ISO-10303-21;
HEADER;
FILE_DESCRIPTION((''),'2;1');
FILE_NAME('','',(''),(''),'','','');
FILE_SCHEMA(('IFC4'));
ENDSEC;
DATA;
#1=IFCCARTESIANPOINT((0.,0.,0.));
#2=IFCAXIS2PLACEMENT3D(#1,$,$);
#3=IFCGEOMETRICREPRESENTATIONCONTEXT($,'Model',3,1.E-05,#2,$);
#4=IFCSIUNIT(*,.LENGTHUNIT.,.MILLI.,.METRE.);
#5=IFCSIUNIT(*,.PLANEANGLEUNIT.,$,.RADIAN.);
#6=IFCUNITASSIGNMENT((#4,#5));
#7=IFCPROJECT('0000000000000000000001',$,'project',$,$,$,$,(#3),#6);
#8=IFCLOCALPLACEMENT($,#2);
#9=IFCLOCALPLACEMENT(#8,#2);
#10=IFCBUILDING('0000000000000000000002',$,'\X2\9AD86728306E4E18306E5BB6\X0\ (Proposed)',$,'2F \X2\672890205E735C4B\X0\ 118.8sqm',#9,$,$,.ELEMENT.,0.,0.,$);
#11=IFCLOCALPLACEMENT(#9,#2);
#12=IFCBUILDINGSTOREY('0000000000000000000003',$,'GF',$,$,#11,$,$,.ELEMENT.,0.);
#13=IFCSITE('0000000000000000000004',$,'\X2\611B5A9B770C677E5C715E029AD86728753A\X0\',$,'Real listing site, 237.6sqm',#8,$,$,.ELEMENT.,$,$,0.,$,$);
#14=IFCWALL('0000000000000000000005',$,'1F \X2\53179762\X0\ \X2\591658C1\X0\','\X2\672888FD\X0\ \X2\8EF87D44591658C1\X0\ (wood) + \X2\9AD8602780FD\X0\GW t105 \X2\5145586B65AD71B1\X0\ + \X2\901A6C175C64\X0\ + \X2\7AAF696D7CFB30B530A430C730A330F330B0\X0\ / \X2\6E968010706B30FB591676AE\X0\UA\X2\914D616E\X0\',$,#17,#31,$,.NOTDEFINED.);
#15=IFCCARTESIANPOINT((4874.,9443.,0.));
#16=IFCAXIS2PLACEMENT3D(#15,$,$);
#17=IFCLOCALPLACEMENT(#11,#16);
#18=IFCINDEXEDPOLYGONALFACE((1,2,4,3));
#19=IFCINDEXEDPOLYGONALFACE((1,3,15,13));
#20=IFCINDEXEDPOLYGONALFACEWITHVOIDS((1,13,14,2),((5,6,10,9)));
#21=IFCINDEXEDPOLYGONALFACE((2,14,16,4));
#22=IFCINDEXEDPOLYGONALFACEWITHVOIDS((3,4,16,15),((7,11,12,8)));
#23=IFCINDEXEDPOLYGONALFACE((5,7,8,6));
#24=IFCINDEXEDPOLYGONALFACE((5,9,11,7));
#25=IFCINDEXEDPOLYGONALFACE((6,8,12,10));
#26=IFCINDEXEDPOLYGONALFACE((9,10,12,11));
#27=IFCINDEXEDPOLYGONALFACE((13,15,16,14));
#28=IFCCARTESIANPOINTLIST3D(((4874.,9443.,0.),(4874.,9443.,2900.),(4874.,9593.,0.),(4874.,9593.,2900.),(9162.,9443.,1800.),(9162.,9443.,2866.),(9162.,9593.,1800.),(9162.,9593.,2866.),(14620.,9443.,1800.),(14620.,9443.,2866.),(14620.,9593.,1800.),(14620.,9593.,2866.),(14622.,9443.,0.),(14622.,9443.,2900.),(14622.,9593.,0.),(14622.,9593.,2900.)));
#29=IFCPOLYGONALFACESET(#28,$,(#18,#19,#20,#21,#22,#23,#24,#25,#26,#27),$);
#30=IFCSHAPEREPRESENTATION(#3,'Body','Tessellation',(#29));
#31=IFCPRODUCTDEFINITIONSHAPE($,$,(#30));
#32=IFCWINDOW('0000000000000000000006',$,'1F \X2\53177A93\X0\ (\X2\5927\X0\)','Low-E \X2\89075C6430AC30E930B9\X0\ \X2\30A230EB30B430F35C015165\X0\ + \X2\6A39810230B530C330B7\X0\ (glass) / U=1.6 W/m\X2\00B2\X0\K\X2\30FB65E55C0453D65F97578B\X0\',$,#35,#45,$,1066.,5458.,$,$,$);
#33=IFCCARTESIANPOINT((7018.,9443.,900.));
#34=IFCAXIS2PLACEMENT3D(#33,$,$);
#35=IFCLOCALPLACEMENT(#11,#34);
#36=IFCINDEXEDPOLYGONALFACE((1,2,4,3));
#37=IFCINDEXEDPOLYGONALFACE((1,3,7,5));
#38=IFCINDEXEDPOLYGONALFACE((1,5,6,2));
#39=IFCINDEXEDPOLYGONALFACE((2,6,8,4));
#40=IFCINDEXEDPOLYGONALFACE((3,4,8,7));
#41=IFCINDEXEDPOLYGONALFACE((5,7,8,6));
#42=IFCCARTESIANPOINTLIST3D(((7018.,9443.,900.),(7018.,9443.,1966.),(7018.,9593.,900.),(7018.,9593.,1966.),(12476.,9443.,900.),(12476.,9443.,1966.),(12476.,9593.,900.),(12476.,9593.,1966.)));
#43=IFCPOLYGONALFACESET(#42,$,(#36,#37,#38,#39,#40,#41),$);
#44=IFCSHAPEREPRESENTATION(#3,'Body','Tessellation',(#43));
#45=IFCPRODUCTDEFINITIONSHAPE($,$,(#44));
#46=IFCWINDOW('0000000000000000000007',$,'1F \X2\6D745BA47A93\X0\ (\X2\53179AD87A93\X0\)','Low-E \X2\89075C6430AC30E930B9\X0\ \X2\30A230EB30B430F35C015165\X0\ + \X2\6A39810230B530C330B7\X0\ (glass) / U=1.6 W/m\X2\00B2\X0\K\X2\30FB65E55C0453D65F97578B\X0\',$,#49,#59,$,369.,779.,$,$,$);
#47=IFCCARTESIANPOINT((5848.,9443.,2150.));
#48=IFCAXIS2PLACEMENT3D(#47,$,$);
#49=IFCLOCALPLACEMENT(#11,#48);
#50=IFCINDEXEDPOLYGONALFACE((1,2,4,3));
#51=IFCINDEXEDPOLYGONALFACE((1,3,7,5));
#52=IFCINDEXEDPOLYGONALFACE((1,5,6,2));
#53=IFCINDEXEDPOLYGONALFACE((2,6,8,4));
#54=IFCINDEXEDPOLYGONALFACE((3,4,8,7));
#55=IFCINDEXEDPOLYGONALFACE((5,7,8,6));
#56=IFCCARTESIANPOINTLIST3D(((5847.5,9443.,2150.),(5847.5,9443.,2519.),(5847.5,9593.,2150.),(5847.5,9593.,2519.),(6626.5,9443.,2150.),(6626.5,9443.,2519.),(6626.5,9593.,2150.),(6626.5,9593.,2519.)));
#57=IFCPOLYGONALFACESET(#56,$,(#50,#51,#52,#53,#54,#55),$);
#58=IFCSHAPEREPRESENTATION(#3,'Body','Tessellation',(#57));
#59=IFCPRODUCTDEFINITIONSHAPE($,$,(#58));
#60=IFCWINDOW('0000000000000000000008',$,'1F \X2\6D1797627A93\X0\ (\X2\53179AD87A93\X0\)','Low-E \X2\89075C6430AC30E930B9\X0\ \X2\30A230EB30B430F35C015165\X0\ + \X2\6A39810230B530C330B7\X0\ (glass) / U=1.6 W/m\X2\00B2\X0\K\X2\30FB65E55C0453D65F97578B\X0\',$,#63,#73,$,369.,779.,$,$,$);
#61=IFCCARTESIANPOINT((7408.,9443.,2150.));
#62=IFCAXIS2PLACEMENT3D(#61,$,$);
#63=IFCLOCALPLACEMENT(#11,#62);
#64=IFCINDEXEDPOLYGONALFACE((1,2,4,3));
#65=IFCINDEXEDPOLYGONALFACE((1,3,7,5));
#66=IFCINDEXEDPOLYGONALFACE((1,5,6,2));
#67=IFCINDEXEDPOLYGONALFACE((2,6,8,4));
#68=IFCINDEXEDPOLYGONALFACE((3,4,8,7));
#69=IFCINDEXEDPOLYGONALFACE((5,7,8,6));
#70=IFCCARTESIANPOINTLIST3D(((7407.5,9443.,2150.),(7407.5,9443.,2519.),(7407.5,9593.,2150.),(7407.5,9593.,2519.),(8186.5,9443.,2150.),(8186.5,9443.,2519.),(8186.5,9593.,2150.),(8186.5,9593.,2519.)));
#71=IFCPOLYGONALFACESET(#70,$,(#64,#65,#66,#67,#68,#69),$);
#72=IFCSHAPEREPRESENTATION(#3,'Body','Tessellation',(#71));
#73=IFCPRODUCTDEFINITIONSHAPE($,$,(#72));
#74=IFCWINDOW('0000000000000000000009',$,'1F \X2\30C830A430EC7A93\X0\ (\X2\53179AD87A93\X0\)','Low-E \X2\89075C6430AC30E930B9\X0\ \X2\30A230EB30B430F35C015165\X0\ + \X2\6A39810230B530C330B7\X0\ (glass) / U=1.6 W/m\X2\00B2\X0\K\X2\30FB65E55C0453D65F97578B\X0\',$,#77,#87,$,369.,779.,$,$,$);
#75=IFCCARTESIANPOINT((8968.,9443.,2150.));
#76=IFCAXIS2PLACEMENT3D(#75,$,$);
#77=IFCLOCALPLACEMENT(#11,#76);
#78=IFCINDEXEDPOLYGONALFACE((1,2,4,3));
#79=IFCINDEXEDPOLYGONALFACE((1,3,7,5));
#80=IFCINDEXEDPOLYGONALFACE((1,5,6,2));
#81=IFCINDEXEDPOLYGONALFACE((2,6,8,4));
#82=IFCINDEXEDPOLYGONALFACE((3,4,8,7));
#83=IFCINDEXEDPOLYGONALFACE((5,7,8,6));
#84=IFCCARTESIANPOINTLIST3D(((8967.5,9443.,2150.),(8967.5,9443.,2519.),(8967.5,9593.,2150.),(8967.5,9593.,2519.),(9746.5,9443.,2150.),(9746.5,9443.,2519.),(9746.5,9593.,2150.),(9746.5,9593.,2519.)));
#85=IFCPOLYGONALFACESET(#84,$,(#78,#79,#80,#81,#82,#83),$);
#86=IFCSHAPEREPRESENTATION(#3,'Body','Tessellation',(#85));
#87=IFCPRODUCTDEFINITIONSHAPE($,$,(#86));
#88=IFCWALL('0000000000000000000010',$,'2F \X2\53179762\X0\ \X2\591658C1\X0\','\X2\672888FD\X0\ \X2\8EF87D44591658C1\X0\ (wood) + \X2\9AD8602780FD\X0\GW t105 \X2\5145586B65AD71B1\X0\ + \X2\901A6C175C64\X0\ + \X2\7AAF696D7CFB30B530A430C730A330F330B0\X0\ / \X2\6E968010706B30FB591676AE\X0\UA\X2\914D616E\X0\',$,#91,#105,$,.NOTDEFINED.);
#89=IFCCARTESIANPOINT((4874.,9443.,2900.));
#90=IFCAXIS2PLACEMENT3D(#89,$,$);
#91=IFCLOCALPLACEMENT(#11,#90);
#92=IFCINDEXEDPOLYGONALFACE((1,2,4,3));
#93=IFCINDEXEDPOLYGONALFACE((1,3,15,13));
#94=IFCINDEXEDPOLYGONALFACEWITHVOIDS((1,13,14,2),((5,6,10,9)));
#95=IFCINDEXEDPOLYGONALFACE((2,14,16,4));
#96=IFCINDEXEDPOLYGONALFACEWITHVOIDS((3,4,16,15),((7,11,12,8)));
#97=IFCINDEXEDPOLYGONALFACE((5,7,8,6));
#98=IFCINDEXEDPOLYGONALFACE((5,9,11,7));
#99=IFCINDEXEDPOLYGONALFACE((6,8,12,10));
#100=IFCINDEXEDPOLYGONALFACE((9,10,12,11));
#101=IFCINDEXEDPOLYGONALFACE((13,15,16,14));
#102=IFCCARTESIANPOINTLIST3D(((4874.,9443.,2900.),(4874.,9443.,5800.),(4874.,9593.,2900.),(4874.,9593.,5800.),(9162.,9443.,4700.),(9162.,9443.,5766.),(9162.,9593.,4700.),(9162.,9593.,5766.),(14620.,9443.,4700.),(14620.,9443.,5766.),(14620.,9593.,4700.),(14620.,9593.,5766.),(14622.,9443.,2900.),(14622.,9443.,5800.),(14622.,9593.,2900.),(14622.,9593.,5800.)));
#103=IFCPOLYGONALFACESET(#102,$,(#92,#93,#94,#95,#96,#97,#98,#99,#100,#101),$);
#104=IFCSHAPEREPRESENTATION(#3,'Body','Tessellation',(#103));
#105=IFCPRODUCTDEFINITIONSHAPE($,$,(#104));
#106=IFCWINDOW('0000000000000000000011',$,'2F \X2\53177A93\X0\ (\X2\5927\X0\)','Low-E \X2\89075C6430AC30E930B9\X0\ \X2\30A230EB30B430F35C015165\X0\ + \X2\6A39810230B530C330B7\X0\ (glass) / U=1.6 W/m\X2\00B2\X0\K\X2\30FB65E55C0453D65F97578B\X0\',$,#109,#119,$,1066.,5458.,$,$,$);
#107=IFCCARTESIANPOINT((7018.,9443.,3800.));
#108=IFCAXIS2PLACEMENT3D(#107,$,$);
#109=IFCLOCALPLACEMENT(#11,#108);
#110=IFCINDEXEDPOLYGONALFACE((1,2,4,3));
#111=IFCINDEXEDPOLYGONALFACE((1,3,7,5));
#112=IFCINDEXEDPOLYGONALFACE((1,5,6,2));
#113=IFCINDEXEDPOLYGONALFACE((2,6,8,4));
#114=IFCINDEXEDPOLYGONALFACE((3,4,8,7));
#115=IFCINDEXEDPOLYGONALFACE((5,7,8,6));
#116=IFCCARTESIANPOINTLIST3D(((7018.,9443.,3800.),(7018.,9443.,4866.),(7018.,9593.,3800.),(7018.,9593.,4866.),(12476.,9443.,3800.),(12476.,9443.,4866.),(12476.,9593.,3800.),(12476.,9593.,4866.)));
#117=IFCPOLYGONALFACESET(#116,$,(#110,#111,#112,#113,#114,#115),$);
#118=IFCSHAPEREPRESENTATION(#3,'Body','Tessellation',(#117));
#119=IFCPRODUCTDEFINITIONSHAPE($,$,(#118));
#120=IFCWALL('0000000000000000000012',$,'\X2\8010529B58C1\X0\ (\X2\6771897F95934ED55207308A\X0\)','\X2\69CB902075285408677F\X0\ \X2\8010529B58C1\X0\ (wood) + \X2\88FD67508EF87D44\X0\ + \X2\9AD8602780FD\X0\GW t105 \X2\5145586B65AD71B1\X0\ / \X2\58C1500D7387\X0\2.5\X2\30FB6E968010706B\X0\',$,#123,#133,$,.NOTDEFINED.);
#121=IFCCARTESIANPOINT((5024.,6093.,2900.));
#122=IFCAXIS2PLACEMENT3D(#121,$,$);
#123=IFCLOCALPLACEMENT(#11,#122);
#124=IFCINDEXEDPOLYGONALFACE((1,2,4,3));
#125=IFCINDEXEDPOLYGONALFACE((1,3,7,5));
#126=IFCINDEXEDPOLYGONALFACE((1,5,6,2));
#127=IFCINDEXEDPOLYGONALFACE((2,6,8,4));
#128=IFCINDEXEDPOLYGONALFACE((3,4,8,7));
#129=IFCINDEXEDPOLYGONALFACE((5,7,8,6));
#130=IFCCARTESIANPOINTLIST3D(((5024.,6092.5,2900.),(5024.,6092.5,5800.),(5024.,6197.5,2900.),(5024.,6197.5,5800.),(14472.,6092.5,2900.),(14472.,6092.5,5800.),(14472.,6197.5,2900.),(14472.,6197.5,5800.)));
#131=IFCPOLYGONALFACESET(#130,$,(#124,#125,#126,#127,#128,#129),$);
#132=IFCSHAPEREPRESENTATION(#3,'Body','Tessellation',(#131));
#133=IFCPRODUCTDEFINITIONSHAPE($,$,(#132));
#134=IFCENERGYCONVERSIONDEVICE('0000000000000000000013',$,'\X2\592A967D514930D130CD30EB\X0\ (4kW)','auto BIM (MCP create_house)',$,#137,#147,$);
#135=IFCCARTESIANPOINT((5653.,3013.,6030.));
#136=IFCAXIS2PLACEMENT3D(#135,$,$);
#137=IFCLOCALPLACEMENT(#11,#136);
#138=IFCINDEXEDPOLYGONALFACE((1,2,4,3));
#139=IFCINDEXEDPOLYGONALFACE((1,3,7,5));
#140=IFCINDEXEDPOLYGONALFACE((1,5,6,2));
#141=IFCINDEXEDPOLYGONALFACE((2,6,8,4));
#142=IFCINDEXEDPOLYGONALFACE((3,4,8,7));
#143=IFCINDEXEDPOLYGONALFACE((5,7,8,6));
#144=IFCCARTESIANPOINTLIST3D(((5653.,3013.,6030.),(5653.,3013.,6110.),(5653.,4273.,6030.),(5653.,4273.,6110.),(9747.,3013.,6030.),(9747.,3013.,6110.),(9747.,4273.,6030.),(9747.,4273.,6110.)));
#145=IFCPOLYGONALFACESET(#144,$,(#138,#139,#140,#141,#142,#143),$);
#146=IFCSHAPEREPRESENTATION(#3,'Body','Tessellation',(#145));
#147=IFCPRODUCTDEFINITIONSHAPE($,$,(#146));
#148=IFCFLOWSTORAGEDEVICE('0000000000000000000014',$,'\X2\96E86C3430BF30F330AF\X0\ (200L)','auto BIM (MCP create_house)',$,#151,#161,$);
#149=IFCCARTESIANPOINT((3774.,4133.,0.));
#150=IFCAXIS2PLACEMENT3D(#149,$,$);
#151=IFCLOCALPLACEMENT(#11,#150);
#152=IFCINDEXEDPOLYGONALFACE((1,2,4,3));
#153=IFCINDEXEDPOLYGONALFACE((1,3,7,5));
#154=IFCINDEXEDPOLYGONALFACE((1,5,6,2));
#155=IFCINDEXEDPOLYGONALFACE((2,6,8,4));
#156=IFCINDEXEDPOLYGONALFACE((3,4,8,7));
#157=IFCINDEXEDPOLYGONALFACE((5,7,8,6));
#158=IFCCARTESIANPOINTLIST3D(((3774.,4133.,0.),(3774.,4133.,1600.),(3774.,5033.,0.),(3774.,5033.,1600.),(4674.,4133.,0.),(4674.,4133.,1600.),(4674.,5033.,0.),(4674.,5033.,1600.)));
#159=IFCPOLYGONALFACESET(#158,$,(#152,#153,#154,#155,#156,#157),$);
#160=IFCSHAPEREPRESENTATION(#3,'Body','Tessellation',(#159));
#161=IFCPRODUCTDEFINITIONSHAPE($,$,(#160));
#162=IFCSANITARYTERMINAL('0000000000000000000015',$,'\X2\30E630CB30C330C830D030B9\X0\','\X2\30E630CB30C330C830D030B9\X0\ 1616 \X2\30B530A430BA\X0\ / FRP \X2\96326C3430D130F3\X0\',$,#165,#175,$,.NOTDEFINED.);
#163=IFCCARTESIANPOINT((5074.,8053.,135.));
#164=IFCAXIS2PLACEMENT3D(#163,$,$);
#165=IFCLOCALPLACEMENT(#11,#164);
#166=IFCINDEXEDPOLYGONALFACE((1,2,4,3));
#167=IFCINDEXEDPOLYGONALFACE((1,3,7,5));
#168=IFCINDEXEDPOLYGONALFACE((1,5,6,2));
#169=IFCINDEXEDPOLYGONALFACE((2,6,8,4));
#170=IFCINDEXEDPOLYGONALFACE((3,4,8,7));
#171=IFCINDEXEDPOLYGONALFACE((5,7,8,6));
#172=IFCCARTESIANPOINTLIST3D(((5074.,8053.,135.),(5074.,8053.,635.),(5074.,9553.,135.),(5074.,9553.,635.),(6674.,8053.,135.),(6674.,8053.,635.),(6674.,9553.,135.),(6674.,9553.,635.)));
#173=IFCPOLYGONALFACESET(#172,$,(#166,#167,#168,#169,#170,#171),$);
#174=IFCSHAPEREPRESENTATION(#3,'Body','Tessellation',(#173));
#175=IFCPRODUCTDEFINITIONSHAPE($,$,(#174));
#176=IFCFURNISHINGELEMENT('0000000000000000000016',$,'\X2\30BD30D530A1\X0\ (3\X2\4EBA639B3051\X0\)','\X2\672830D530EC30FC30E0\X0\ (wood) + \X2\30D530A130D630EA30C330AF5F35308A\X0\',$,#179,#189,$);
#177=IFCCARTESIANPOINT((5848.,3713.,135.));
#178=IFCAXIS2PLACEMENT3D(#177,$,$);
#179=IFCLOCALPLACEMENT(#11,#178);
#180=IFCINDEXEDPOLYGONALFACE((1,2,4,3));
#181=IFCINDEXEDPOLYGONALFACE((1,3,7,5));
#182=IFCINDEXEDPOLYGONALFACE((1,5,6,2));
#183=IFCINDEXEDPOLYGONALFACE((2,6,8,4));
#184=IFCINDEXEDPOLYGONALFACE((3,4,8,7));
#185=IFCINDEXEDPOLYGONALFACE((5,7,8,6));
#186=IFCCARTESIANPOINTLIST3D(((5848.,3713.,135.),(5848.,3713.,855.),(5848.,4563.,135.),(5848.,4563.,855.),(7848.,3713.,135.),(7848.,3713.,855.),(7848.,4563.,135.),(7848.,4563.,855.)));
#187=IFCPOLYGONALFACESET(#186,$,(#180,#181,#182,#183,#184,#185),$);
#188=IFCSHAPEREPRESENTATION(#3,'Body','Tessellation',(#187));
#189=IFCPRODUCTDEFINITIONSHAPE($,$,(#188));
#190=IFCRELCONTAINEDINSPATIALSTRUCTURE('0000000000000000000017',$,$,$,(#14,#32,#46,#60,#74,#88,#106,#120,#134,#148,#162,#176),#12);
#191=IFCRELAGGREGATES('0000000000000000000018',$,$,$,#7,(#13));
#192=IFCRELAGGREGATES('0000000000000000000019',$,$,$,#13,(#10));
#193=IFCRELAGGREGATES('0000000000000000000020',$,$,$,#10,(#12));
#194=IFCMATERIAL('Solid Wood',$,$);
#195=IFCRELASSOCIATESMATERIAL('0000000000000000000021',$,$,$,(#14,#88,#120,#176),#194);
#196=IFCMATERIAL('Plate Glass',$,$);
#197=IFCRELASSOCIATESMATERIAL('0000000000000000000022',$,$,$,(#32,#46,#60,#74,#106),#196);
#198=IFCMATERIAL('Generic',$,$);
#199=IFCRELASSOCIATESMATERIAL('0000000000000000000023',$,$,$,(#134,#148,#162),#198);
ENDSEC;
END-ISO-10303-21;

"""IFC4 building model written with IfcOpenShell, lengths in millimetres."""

from ifc_helpers import new_model, si_unit, frame, frame_2d, origin, place, context, project, spatial, rectangle, extrude, material, element, fill, save


model = new_model("IFC4")

# Units and contexts
model_context = context("Model", 3, precision=1e-05, world=origin())
ifc_project = project(units=[si_unit("LENGTHUNIT", "METRE", prefix="MILLI"), si_unit("PLANEANGLEUNIT", "RADIAN")], contexts=[model_context])

# Site, building, storey
site_placement = place(None, origin())
site = spatial("IfcSite", under=ifc_project, at=site_placement, Name="愛媛県松山市高木町", ObjectType="Real listing site, 237.6sqm", CompositionType="ELEMENT", RefElevation=0.0)
building_placement = place(site_placement, origin())
building = spatial("IfcBuilding", under=site, at=building_placement, Name="高木の丘の家 (Proposed)", ObjectType="2F 木造平屋 118.8sqm", CompositionType="ELEMENT", ElevationOfRefHeight=0.0, ElevationOfTerrain=0.0)
storey_placement = place(building_placement, origin())
storey = spatial("IfcBuildingStorey", under=building, at=storey_placement, Name="GF", CompositionType="ELEMENT", Elevation=0.0)

# Wall, openings, windows
ifc_material_1 = material(Name="Solid Wood")
wall_1_placement = place(storey_placement, frame((4874.0, 9443.0, 0.0)))
wall_1 = element("IfcWall", 1, at=wall_1_placement, inside=storey, material=ifc_material_1, Name="1F 北面 外壁", Description="木製 軸組外壁 (wood) + 高性能GW t105 充填断熱 + 通気層 + 窯業系サイディング / 準耐火・外皮UA配慮", PredefinedType="NOTDEFINED", context=model_context, shape_type="SweptSolid", body=[
    extrude(rectangle(XDim=9748.0, YDim=150.0, at=frame_2d((4874.0, 75.0))), frame((4874.0, 9443.0, 0.0)), (0.0, 0.0, 1.0), 2900.0),
])
opening_1_placement = place(storey_placement, frame((7018.0, 9443.0, 900.0)))
opening_1 = element("IfcOpeningElement", 2, at=opening_1_placement, cuts=wall_1, PredefinedType="NOTDEFINED", context=model_context, shape_type="SweptSolid", body=[
    extrude(rectangle(XDim=5458.0, YDim=150.0, at=frame_2d((2729.0, 75.0))), frame((7018.0, 9443.0, 900.0)), (0.0, 0.0, 1.0), 1066.0),
])
opening_2_placement = place(storey_placement, frame((5848.0, 9443.0, 2150.0)))
opening_2 = element("IfcOpeningElement", 3, at=opening_2_placement, cuts=wall_1, PredefinedType="NOTDEFINED", context=model_context, shape_type="SweptSolid", body=[
    extrude(rectangle(XDim=779.0, YDim=150.0, at=frame_2d((389.0, 75.0))), frame((5848.0, 9443.0, 2150.0)), (0.0, 0.0, 1.0), 369.0),
])
opening_3_placement = place(storey_placement, frame((7408.0, 9443.0, 2150.0)))
opening_3 = element("IfcOpeningElement", 4, at=opening_3_placement, cuts=wall_1, PredefinedType="NOTDEFINED", context=model_context, shape_type="SweptSolid", body=[
    extrude(rectangle(XDim=779.0, YDim=150.0, at=frame_2d((389.0, 75.0))), frame((7408.0, 9443.0, 2150.0)), (0.0, 0.0, 1.0), 369.0),
])
opening_4_placement = place(storey_placement, frame((8968.0, 9443.0, 2150.0)))
opening_4 = element("IfcOpeningElement", 5, at=opening_4_placement, cuts=wall_1, PredefinedType="NOTDEFINED", context=model_context, shape_type="SweptSolid", body=[
    extrude(rectangle(XDim=779.0, YDim=150.0, at=frame_2d((389.0, 75.0))), frame((8968.0, 9443.0, 2150.0)), (0.0, 0.0, 1.0), 369.0),
])
ifc_material_2 = material(Name="Plate Glass")
window_1_placement = place(storey_placement, frame((7018.0, 9443.0, 900.0)))
window_1 = element("IfcWindow", 6, at=window_1_placement, inside=storey, material=ifc_material_2, Name="1F 北窓 (大)", Description="Low-E 複層ガラス アルゴン封入 + 樹脂サッシ (glass) / U=1.6 W/m²K・日射取得型", OverallHeight=1066.0, OverallWidth=5458.0, context=model_context, shape_type="SweptSolid", body=[
    extrude(rectangle(XDim=5458.0, YDim=150.0, at=frame_2d((2729.0, 75.0))), frame((7018.0, 9443.0, 900.0)), (0.0, 0.0, 1.0), 1066.0),
])
fill(opening_1, window_1)
window_2_placement = place(storey_placement, frame((5848.0, 9443.0, 2150.0)))
window_2 = element("IfcWindow", 7, at=window_2_placement, inside=storey, material=ifc_material_2, Name="1F 浴室窓 (北高窓)", Description="Low-E 複層ガラス アルゴン封入 + 樹脂サッシ (glass) / U=1.6 W/m²K・日射取得型", OverallHeight=369.0, OverallWidth=779.0, context=model_context, shape_type="SweptSolid", body=[
    extrude(rectangle(XDim=779.0, YDim=150.0, at=frame_2d((389.0, 75.0))), frame((5848.0, 9443.0, 2150.0)), (0.0, 0.0, 1.0), 369.0),
])
fill(opening_2, window_2)
window_3_placement = place(storey_placement, frame((7408.0, 9443.0, 2150.0)))
window_3 = element("IfcWindow", 8, at=window_3_placement, inside=storey, material=ifc_material_2, Name="1F 洗面窓 (北高窓)", Description="Low-E 複層ガラス アルゴン封入 + 樹脂サッシ (glass) / U=1.6 W/m²K・日射取得型", OverallHeight=369.0, OverallWidth=779.0, context=model_context, shape_type="SweptSolid", body=[
    extrude(rectangle(XDim=779.0, YDim=150.0, at=frame_2d((389.0, 75.0))), frame((7408.0, 9443.0, 2150.0)), (0.0, 0.0, 1.0), 369.0),
])
fill(opening_3, window_3)
window_4_placement = place(storey_placement, frame((8968.0, 9443.0, 2150.0)))
window_4 = element("IfcWindow", 9, at=window_4_placement, inside=storey, material=ifc_material_2, Name="1F トイレ窓 (北高窓)", Description="Low-E 複層ガラス アルゴン封入 + 樹脂サッシ (glass) / U=1.6 W/m²K・日射取得型", OverallHeight=369.0, OverallWidth=779.0, context=model_context, shape_type="SweptSolid", body=[
    extrude(rectangle(XDim=779.0, YDim=150.0, at=frame_2d((389.0, 75.0))), frame((8968.0, 9443.0, 2150.0)), (0.0, 0.0, 1.0), 369.0),
])
fill(opening_4, window_4)

# Wall, opening, window
wall_2_placement = place(storey_placement, frame((4874.0, 9443.0, 2900.0)))
wall_2 = element("IfcWall", 10, at=wall_2_placement, inside=storey, material=ifc_material_1, Name="2F 北面 外壁", Description="木製 軸組外壁 (wood) + 高性能GW t105 充填断熱 + 通気層 + 窯業系サイディング / 準耐火・外皮UA配慮", PredefinedType="NOTDEFINED", context=model_context, shape_type="SweptSolid", body=[
    extrude(rectangle(XDim=9748.0, YDim=150.0, at=frame_2d((4874.0, 75.0))), frame((4874.0, 9443.0, 2900.0)), (0.0, 0.0, 1.0), 2900.0),
])
opening_5_placement = place(storey_placement, frame((7018.0, 9443.0, 3800.0)))
opening_5 = element("IfcOpeningElement", 11, at=opening_5_placement, cuts=wall_2, PredefinedType="NOTDEFINED", context=model_context, shape_type="SweptSolid", body=[
    extrude(rectangle(XDim=5458.0, YDim=150.0, at=frame_2d((2729.0, 75.0))), frame((7018.0, 9443.0, 3800.0)), (0.0, 0.0, 1.0), 1066.0),
])
window_5_placement = place(storey_placement, frame((7018.0, 9443.0, 3800.0)))
window_5 = element("IfcWindow", 12, at=window_5_placement, inside=storey, material=ifc_material_2, Name="2F 北窓 (大)", Description="Low-E 複層ガラス アルゴン封入 + 樹脂サッシ (glass) / U=1.6 W/m²K・日射取得型", OverallHeight=1066.0, OverallWidth=5458.0, context=model_context, shape_type="SweptSolid", body=[
    extrude(rectangle(XDim=5458.0, YDim=150.0, at=frame_2d((2729.0, 75.0))), frame((7018.0, 9443.0, 3800.0)), (0.0, 0.0, 1.0), 1066.0),
])
fill(opening_5, window_5)

# Wall
wall_3_placement = place(storey_placement, frame((5024.0, 6093.0, 2900.0)))
element("IfcWall", 13, at=wall_3_placement, inside=storey, material=ifc_material_1, Name="耐力壁 (東西間仕切り)", Description="構造用合板 耐力壁 (wood) + 製材軸組 + 高性能GW t105 充填断熱 / 壁倍率2.5・準耐火", PredefinedType="NOTDEFINED", context=model_context, shape_type="SweptSolid", body=[
    extrude(rectangle(XDim=9448.0, YDim=105.0, at=frame_2d((4724.0, 52.0))), frame((5024.0, 6093.0, 2900.0)), (0.0, 0.0, 1.0), 2900.0),
])

# Energy conversion device
ifc_material_3 = material(Name="Generic")
energy_conversion_device_placement = place(storey_placement, frame((5653.0, 3013.0, 6030.0)))
element("IfcEnergyConversionDevice", 14, at=energy_conversion_device_placement, inside=storey, material=ifc_material_3, Name="太陽光パネル (4kW)", Description="auto BIM (MCP create_house)", context=model_context, shape_type="SweptSolid", body=[
    extrude(rectangle(XDim=4094.0, YDim=1260.0, at=frame_2d((2047.0, 630.0))), frame((5653.0, 3013.0, 6030.0)), (0.0, 0.0, 1.0), 80.0),
])

# Flow storage device
flow_storage_device_placement = place(storey_placement, frame((3774.0, 4133.0, 0.0)))
element("IfcFlowStorageDevice", 15, at=flow_storage_device_placement, inside=storey, material=ifc_material_3, Name="雨水タンク (200L)", Description="auto BIM (MCP create_house)", context=model_context, shape_type="SweptSolid", body=[
    extrude(rectangle(XDim=900.0, YDim=900.0, at=frame_2d((450.0, 450.0))), frame((3774.0, 4133.0, 0.0)), (0.0, 0.0, 1.0), 1600.0),
])

# Sanitary terminal
sanitary_terminal_placement = place(storey_placement, frame((5074.0, 8053.0, 135.0)))
element("IfcSanitaryTerminal", 16, at=sanitary_terminal_placement, inside=storey, material=ifc_material_3, Name="ユニットバス", Description="ユニットバス 1616 サイズ / FRP 防水パン", PredefinedType="NOTDEFINED", context=model_context, shape_type="SweptSolid", body=[
    extrude(rectangle(XDim=1600.0, YDim=1500.0, at=frame_2d((800.0, 750.0))), frame((5074.0, 8053.0, 135.0)), (0.0, 0.0, 1.0), 500.0),
])

# Furnishing element
furnishing_1_placement = place(storey_placement, frame((5848.0, 3713.0, 135.0)))
element("IfcFurnishingElement", 17, at=furnishing_1_placement, inside=storey, material=ifc_material_1, Name="ソファ (3人掛け)", Description="木フレーム (wood) + ファブリック張り", context=model_context, shape_type="SweptSolid", body=[
    extrude(rectangle(XDim=2000.0, YDim=850.0, at=frame_2d((1000.0, 425.0))), frame((5848.0, 3713.0, 135.0)), (0.0, 0.0, 1.0), 720.0),
])

save(model, "model.ifc")
